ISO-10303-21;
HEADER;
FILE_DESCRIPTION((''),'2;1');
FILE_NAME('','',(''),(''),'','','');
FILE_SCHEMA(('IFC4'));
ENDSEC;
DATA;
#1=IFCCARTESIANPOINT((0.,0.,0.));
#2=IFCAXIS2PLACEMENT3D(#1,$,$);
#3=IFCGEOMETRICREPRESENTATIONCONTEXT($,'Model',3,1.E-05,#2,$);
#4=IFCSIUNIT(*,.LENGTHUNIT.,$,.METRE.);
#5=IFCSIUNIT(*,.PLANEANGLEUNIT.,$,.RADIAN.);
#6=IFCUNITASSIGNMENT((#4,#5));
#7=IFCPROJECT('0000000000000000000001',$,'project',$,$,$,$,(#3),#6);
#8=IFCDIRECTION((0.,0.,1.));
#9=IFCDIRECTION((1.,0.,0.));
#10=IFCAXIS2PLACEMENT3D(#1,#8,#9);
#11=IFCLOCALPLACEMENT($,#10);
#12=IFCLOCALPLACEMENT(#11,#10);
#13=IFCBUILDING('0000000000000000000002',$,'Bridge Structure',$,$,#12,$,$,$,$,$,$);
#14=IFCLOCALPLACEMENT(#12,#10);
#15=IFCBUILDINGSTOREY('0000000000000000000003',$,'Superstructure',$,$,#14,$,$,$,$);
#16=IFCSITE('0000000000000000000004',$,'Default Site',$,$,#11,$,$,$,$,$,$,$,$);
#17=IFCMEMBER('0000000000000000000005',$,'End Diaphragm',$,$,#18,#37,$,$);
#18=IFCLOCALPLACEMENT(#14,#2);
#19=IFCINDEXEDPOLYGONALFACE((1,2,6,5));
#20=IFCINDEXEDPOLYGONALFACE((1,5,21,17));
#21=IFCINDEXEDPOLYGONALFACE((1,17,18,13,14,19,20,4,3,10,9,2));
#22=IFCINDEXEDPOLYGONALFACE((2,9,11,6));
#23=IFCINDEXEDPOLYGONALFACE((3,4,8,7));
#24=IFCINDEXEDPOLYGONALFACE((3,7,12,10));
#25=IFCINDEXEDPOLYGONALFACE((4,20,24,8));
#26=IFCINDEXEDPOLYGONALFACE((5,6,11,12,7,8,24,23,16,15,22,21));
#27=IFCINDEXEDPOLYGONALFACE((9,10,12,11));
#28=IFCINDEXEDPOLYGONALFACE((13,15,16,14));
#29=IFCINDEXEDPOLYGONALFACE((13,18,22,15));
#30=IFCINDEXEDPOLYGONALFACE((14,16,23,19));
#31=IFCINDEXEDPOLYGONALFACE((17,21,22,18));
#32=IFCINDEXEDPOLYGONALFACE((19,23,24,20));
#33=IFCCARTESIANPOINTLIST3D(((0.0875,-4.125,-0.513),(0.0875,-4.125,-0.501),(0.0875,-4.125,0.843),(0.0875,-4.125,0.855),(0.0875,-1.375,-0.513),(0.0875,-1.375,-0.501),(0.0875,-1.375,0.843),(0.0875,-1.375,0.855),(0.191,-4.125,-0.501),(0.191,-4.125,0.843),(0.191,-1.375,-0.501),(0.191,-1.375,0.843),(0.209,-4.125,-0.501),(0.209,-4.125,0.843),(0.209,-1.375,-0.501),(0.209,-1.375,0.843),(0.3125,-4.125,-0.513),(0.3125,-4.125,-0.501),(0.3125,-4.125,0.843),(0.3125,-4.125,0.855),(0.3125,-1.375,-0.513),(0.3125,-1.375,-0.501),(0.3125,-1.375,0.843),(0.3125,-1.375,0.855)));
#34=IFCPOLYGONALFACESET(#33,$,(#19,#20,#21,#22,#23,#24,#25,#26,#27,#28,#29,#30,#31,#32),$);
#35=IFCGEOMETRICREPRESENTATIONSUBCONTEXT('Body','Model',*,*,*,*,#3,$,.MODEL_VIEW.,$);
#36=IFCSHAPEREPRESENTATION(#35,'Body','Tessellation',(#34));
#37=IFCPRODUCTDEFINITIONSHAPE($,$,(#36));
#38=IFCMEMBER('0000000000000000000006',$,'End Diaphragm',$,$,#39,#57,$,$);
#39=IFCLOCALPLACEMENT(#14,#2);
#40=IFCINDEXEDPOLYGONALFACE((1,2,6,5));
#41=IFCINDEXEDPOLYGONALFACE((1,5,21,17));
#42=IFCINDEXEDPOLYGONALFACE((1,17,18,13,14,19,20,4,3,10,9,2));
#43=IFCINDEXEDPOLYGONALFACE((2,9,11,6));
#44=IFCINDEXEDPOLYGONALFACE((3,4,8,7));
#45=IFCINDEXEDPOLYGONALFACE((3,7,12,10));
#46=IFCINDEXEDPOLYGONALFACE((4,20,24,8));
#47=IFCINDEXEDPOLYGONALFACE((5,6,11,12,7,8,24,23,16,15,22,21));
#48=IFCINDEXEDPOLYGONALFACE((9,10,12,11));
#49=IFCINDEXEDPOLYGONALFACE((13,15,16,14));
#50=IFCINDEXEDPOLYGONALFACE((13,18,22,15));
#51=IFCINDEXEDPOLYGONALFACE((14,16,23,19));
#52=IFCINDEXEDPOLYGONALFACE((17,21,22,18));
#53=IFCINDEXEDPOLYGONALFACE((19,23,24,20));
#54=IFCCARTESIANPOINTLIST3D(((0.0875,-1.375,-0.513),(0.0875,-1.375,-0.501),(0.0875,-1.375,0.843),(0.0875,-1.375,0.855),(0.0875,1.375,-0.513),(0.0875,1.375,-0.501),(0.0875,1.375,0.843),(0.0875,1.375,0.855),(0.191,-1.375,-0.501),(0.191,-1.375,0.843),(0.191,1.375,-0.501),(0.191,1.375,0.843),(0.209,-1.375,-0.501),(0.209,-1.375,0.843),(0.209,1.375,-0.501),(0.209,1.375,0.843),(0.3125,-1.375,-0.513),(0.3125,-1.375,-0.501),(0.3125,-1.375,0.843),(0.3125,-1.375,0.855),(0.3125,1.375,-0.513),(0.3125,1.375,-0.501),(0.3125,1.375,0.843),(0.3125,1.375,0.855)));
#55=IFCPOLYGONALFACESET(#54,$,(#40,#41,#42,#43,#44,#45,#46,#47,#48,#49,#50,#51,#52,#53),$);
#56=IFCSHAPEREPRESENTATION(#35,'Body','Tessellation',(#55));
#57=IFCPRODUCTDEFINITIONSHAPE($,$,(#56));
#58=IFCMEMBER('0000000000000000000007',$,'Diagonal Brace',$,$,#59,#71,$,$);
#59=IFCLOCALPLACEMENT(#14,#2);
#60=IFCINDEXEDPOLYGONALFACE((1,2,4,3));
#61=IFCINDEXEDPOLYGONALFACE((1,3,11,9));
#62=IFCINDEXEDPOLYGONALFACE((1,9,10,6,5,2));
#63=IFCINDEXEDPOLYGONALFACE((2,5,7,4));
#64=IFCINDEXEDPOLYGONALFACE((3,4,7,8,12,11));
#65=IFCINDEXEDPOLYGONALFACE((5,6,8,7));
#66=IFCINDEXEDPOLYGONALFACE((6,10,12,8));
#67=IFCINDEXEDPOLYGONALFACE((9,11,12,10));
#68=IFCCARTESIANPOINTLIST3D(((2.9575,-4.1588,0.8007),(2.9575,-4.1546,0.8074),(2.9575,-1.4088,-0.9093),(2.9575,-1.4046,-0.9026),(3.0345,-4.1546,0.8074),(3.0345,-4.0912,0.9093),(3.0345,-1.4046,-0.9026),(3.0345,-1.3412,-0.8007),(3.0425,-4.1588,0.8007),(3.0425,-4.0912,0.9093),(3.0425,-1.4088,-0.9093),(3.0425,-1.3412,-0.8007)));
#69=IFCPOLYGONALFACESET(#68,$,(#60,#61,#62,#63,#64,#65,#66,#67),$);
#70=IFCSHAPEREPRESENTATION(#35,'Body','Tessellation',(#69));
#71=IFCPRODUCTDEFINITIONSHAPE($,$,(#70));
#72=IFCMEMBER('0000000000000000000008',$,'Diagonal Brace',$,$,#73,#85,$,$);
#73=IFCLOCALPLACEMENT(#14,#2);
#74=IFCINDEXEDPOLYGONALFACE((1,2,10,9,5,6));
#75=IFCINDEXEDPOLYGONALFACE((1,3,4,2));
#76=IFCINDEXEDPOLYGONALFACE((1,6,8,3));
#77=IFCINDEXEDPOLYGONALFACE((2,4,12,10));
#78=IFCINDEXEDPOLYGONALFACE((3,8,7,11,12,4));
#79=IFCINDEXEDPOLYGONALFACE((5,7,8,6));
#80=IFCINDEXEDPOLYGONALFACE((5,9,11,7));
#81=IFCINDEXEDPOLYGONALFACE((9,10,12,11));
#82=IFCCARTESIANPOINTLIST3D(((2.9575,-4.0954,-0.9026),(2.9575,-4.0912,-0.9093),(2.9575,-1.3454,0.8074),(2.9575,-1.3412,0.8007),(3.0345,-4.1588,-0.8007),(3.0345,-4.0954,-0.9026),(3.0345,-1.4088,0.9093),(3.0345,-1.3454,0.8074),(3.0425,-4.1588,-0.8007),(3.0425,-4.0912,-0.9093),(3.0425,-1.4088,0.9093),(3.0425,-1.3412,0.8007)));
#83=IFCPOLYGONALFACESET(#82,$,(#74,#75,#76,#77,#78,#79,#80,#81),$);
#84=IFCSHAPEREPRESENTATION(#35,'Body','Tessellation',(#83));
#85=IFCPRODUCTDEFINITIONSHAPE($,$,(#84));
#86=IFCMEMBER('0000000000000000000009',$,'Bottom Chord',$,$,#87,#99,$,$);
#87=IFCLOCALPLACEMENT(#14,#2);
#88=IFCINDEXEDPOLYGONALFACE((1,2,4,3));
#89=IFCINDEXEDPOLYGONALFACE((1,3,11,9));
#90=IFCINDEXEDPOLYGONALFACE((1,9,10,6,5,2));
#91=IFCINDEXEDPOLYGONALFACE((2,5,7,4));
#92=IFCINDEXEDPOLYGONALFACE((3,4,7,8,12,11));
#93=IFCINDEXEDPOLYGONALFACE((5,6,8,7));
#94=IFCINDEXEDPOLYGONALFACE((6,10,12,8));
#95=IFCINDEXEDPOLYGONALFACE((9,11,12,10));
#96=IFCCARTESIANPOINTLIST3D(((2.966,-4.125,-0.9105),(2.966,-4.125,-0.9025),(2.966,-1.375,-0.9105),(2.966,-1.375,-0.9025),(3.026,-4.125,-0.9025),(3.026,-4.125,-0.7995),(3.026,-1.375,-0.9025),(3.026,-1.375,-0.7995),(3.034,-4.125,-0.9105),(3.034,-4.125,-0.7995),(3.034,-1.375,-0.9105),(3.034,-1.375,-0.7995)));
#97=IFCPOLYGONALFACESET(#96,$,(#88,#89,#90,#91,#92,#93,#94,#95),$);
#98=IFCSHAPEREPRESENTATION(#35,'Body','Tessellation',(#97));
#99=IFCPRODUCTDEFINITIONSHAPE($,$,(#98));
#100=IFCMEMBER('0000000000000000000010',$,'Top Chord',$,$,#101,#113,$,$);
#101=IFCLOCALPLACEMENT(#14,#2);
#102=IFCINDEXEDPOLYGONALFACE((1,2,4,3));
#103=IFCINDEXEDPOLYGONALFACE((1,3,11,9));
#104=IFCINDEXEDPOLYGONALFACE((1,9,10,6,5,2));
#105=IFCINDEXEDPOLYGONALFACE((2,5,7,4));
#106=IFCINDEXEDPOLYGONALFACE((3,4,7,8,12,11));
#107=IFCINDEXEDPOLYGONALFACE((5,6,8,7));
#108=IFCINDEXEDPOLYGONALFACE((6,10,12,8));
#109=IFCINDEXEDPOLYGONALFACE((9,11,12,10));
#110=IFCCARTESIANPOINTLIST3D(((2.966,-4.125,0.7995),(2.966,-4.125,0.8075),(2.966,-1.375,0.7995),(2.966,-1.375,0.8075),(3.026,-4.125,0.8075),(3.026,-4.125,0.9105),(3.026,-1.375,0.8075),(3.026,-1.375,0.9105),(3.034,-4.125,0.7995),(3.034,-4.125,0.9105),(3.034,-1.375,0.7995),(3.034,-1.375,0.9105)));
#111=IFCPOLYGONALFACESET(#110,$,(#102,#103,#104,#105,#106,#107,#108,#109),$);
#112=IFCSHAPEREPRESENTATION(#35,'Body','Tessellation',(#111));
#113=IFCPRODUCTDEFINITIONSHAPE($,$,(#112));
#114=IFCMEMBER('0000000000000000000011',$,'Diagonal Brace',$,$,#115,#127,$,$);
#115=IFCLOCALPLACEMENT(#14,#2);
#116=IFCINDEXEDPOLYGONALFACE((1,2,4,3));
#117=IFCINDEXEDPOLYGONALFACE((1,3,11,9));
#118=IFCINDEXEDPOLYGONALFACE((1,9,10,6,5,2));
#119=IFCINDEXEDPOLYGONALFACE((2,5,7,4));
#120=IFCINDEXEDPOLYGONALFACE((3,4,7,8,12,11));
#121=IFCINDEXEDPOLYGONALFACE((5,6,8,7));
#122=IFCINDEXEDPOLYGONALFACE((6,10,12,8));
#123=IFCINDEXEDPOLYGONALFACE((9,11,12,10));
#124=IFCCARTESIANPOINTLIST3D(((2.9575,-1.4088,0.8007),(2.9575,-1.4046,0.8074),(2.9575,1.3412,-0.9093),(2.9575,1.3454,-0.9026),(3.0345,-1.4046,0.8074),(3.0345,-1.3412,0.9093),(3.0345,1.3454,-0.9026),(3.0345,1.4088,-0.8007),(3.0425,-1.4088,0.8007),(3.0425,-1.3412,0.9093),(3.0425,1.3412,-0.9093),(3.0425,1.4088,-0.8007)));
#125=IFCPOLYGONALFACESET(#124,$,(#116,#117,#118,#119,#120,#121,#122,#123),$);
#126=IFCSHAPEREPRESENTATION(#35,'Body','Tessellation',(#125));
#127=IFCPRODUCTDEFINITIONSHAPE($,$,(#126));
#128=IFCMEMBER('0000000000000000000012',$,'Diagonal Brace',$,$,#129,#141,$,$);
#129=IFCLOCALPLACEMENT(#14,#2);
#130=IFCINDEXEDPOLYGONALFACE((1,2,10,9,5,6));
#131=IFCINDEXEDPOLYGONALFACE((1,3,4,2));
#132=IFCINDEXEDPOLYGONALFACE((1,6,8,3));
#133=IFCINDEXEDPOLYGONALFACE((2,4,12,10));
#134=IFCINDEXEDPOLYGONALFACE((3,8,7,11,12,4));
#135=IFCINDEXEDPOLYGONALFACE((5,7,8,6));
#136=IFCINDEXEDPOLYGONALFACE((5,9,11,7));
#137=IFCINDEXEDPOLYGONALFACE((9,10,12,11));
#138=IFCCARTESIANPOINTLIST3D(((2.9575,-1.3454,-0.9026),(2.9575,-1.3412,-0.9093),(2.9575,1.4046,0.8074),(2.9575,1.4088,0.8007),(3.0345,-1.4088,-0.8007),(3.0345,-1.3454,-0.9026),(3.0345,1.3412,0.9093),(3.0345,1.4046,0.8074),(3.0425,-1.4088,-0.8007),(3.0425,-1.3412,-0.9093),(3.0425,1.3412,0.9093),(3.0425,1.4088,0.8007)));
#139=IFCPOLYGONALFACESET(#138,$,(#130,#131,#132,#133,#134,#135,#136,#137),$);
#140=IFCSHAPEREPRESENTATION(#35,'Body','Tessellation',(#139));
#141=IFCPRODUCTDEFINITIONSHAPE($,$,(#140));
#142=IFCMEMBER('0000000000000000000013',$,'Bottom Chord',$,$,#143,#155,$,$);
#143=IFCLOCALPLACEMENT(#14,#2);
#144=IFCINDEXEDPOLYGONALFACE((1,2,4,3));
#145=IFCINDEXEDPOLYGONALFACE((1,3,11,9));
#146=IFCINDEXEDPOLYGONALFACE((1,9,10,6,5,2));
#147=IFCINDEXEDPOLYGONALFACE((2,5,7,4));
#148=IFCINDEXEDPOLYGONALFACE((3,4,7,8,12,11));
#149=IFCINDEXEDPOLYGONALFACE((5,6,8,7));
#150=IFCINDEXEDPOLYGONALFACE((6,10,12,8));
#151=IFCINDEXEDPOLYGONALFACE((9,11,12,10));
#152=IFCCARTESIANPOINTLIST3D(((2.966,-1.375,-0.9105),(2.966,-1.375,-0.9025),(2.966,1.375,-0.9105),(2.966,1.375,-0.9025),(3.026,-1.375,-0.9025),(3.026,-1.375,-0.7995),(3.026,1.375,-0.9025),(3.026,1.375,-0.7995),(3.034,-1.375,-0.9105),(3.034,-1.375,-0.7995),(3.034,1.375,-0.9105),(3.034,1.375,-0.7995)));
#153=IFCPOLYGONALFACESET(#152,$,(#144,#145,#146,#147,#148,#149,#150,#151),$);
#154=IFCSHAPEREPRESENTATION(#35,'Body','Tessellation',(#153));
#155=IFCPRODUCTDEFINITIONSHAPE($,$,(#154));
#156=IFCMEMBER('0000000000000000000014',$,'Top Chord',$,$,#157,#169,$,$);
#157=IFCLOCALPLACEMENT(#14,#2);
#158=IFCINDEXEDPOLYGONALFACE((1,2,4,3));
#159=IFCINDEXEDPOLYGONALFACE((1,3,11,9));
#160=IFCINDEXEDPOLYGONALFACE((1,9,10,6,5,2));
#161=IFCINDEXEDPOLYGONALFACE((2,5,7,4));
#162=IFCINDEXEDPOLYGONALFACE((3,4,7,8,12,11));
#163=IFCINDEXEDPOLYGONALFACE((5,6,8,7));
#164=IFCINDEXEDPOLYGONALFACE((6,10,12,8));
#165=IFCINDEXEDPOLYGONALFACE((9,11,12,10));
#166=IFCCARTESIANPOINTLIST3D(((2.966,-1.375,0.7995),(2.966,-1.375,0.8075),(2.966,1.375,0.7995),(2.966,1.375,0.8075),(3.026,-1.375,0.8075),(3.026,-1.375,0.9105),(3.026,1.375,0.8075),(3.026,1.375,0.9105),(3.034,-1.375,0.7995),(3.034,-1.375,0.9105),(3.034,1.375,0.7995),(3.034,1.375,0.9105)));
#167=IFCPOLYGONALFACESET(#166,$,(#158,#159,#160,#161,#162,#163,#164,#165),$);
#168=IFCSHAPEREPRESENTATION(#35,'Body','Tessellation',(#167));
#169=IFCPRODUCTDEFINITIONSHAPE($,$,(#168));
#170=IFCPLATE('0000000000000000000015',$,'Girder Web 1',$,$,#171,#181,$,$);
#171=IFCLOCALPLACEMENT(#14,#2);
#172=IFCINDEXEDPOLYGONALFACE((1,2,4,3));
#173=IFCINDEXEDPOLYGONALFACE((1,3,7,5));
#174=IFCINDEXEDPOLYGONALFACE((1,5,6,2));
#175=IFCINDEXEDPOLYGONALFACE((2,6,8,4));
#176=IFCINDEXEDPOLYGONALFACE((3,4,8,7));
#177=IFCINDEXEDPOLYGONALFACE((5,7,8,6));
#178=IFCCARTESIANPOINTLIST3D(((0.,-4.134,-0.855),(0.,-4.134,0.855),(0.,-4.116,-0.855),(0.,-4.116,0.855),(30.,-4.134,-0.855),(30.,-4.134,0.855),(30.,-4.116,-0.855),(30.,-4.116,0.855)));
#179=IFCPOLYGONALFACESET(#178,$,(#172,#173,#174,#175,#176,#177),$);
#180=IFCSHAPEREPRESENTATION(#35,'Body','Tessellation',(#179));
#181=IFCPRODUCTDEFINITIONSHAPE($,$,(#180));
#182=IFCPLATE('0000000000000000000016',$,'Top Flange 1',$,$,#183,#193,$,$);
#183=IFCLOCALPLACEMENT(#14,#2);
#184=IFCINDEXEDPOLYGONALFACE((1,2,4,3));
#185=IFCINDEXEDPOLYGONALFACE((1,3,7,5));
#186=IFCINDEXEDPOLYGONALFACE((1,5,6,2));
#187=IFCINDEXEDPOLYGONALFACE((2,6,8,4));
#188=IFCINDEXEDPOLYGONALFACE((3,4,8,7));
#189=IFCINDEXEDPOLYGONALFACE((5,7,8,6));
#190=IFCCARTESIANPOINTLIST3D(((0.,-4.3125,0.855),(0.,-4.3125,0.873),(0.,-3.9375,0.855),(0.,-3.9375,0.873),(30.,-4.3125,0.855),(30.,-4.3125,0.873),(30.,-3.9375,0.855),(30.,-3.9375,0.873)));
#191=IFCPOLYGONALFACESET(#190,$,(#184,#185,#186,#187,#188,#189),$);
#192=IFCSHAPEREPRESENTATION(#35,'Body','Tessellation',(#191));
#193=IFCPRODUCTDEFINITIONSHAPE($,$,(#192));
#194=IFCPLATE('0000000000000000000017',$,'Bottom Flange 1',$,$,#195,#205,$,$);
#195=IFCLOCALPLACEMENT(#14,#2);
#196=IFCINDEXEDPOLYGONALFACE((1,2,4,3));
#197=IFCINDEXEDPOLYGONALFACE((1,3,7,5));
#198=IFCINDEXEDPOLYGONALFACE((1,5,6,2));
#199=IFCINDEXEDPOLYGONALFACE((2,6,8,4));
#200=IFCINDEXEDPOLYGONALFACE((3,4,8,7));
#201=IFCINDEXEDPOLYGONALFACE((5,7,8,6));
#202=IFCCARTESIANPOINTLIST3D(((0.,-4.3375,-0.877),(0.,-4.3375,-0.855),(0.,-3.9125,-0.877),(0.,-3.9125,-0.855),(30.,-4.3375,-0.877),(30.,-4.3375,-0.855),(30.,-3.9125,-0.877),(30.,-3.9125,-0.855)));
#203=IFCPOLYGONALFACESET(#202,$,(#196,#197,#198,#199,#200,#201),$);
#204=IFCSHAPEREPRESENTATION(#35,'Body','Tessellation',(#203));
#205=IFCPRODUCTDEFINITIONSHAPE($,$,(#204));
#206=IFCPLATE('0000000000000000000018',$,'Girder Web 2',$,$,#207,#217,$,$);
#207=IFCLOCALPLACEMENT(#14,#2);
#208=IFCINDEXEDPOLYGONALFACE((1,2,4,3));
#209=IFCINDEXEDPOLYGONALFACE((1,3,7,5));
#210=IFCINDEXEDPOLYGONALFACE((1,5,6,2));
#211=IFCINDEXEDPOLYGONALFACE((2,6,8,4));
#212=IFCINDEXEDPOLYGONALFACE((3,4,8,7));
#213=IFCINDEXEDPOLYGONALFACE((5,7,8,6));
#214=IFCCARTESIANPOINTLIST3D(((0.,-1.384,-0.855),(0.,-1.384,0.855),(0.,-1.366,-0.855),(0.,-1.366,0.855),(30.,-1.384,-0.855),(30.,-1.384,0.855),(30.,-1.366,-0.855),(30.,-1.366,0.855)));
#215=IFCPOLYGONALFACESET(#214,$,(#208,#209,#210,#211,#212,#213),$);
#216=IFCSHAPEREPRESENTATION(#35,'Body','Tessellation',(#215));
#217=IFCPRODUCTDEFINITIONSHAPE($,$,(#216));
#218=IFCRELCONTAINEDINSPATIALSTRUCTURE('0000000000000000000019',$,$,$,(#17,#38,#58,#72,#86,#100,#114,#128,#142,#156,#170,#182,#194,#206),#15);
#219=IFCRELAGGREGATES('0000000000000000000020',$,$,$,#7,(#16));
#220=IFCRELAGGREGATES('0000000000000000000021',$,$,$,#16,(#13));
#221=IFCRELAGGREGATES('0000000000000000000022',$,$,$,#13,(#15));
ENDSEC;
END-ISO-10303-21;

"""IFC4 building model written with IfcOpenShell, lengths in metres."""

from ifc_helpers import new_model, si_unit, frame, origin, origin_with_axes, origin_2d_with_axis, place, context, subcontext, project, spatial, rectangle, i_section, l_section, extrude, element, save


model = new_model("IFC4")

# Units and contexts
model_context = context("Model", 3, precision=1e-05, world=origin())
body_context = subcontext(model_context, "Body", "Model", "MODEL_VIEW")
ifc_project = project(units=[si_unit("LENGTHUNIT", "METRE"), si_unit("PLANEANGLEUNIT", "RADIAN")], contexts=[model_context])

# Site, building, storey
site_placement = place(None, origin_with_axes())
site = spatial("IfcSite", under=ifc_project, at=site_placement, Name="Default Site")
building_placement = place(site_placement, origin_with_axes())
building = spatial("IfcBuilding", under=site, at=building_placement, Name="Bridge Structure")
storey_placement = place(building_placement, origin_with_axes())
storey = spatial("IfcBuildingStorey", under=building, at=storey_placement, Name="Superstructure")

# Members
for number, where, z_axis, x_axis, name in (
    (1, (0.2, -4.125, 0.171), (0.0, 1.0, 0.0), (-1.0, 0.0, 0.0), "End Diaphragm"),
    (2, (0.2, -1.375, 0.171), (0.0, 1.0, 0.0), (-1.0, 0.0, 0.0), "End Diaphragm"),
):
    element("IfcMember", number, at=place(storey_placement, frame(where, z_axis=z_axis, x_axis=x_axis)), inside=storey, Name=name, context=body_context, shape_type="SweptSolid", body=[
        extrude(i_section(OverallWidth=0.225, OverallDepth=1.368, WebThickness=0.018, FlangeThickness=0.012, at=origin_2d_with_axis()), origin_with_axes(), (0.0, 0.0, 1.0), 2.75),
    ])
for number, where, z_axis, x_axis, name in (
    (3, (3.0, -4.125, 0.855), (0.0, 0.84921, -0.528055), (-1.0, 0.0, 0.0), "Diagonal Brace"),
    (4, (3.0, -4.125, -0.855), (0.0, 0.84921, 0.528055), (-1.0, 0.0, 0.0), "Diagonal Brace"),
):
    element("IfcMember", number, at=place(storey_placement, frame(where, z_axis=z_axis, x_axis=x_axis)), inside=storey, Name=name, context=body_context, shape_type="SweptSolid", body=[
        extrude(l_section(Depth=0.128, Width=0.085, Thickness=0.008, at=origin_2d_with_axis()), origin_with_axes(), (0.0, 0.0, 1.0), 3.2383),
    ])
for number, where, z_axis, x_axis, name in (
    (5, (3.0, -4.125, -0.855), (0.0, 1.0, 0.0), (-1.0, 0.0, 0.0), "Bottom Chord"),
    (6, (3.0, -4.125, 0.855), (0.0, 1.0, 0.0), (-1.0, 0.0, 0.0), "Top Chord"),
):
    element("IfcMember", number, at=place(storey_placement, frame(where, z_axis=z_axis, x_axis=x_axis)), inside=storey, Name=name, context=body_context, shape_type="SweptSolid", body=[
        extrude(l_section(Depth=0.111, Width=0.068, Thickness=0.008, at=origin_2d_with_axis()), origin_with_axes(), (0.0, 0.0, 1.0), 2.75),
    ])
for number, where, z_axis, x_axis, name in (
    (7, (3.0, -1.375, 0.855), (0.0, 0.84921, -0.528055), (-1.0, 0.0, 0.0), "Diagonal Brace"),
    (8, (3.0, -1.375, -0.855), (0.0, 0.84921, 0.528055), (-1.0, 0.0, 0.0), "Diagonal Brace"),
):
    element("IfcMember", number, at=place(storey_placement, frame(where, z_axis=z_axis, x_axis=x_axis)), inside=storey, Name=name, context=body_context, shape_type="SweptSolid", body=[
        extrude(l_section(Depth=0.128, Width=0.085, Thickness=0.008, at=origin_2d_with_axis()), origin_with_axes(), (0.0, 0.0, 1.0), 3.2383),
    ])
for number, where, z_axis, x_axis, name in (
    (9, (3.0, -1.375, -0.855), (0.0, 1.0, 0.0), (-1.0, 0.0, 0.0), "Bottom Chord"),
    (10, (3.0, -1.375, 0.855), (0.0, 1.0, 0.0), (-1.0, 0.0, 0.0), "Top Chord"),
):
    element("IfcMember", number, at=place(storey_placement, frame(where, z_axis=z_axis, x_axis=x_axis)), inside=storey, Name=name, context=body_context, shape_type="SweptSolid", body=[
        extrude(l_section(Depth=0.111, Width=0.068, Thickness=0.008, at=origin_2d_with_axis()), origin_with_axes(), (0.0, 0.0, 1.0), 2.75),
    ])

# Plates
plate_1_placement = place(storey_placement, frame((0.0, -4.125, 0.0), z_axis=(1.0, 0.0, 0.0), x_axis=(0.0, 1.0, 0.0)))
element("IfcPlate", 11, at=plate_1_placement, inside=storey, Name="Girder Web 1", context=body_context, shape_type="SweptSolid", body=[
    extrude(rectangle(XDim=0.018, YDim=1.71, at=origin_2d_with_axis()), origin_with_axes(), (0.0, 0.0, 1.0), 30.0),
])
plate_2_placement = place(storey_placement, frame((0.0, -4.125, 0.864), z_axis=(1.0, 0.0, 0.0), x_axis=(0.0, 1.0, 0.0)))
element("IfcPlate", 12, at=plate_2_placement, inside=storey, Name="Top Flange 1", context=body_context, shape_type="SweptSolid", body=[
    extrude(rectangle(XDim=0.375, YDim=0.018, at=origin_2d_with_axis()), origin_with_axes(), (0.0, 0.0, 1.0), 30.0),
])
plate_3_placement = place(storey_placement, frame((0.0, -4.125, -0.866), z_axis=(1.0, 0.0, 0.0), x_axis=(0.0, 1.0, 0.0)))
element("IfcPlate", 13, at=plate_3_placement, inside=storey, Name="Bottom Flange 1", context=body_context, shape_type="SweptSolid", body=[
    extrude(rectangle(XDim=0.425, YDim=0.022, at=origin_2d_with_axis()), origin_with_axes(), (0.0, 0.0, 1.0), 30.0),
])
plate_4_placement = place(storey_placement, frame((0.0, -1.375, 0.0), z_axis=(1.0, 0.0, 0.0), x_axis=(0.0, 1.0, 0.0)))
element("IfcPlate", 14, at=plate_4_placement, inside=storey, Name="Girder Web 2", context=body_context, shape_type="SweptSolid", body=[
    extrude(rectangle(XDim=0.018, YDim=1.71, at=origin_2d_with_axis()), origin_with_axes(), (0.0, 0.0, 1.0), 30.0),
])

save(model, "model.ifc")
